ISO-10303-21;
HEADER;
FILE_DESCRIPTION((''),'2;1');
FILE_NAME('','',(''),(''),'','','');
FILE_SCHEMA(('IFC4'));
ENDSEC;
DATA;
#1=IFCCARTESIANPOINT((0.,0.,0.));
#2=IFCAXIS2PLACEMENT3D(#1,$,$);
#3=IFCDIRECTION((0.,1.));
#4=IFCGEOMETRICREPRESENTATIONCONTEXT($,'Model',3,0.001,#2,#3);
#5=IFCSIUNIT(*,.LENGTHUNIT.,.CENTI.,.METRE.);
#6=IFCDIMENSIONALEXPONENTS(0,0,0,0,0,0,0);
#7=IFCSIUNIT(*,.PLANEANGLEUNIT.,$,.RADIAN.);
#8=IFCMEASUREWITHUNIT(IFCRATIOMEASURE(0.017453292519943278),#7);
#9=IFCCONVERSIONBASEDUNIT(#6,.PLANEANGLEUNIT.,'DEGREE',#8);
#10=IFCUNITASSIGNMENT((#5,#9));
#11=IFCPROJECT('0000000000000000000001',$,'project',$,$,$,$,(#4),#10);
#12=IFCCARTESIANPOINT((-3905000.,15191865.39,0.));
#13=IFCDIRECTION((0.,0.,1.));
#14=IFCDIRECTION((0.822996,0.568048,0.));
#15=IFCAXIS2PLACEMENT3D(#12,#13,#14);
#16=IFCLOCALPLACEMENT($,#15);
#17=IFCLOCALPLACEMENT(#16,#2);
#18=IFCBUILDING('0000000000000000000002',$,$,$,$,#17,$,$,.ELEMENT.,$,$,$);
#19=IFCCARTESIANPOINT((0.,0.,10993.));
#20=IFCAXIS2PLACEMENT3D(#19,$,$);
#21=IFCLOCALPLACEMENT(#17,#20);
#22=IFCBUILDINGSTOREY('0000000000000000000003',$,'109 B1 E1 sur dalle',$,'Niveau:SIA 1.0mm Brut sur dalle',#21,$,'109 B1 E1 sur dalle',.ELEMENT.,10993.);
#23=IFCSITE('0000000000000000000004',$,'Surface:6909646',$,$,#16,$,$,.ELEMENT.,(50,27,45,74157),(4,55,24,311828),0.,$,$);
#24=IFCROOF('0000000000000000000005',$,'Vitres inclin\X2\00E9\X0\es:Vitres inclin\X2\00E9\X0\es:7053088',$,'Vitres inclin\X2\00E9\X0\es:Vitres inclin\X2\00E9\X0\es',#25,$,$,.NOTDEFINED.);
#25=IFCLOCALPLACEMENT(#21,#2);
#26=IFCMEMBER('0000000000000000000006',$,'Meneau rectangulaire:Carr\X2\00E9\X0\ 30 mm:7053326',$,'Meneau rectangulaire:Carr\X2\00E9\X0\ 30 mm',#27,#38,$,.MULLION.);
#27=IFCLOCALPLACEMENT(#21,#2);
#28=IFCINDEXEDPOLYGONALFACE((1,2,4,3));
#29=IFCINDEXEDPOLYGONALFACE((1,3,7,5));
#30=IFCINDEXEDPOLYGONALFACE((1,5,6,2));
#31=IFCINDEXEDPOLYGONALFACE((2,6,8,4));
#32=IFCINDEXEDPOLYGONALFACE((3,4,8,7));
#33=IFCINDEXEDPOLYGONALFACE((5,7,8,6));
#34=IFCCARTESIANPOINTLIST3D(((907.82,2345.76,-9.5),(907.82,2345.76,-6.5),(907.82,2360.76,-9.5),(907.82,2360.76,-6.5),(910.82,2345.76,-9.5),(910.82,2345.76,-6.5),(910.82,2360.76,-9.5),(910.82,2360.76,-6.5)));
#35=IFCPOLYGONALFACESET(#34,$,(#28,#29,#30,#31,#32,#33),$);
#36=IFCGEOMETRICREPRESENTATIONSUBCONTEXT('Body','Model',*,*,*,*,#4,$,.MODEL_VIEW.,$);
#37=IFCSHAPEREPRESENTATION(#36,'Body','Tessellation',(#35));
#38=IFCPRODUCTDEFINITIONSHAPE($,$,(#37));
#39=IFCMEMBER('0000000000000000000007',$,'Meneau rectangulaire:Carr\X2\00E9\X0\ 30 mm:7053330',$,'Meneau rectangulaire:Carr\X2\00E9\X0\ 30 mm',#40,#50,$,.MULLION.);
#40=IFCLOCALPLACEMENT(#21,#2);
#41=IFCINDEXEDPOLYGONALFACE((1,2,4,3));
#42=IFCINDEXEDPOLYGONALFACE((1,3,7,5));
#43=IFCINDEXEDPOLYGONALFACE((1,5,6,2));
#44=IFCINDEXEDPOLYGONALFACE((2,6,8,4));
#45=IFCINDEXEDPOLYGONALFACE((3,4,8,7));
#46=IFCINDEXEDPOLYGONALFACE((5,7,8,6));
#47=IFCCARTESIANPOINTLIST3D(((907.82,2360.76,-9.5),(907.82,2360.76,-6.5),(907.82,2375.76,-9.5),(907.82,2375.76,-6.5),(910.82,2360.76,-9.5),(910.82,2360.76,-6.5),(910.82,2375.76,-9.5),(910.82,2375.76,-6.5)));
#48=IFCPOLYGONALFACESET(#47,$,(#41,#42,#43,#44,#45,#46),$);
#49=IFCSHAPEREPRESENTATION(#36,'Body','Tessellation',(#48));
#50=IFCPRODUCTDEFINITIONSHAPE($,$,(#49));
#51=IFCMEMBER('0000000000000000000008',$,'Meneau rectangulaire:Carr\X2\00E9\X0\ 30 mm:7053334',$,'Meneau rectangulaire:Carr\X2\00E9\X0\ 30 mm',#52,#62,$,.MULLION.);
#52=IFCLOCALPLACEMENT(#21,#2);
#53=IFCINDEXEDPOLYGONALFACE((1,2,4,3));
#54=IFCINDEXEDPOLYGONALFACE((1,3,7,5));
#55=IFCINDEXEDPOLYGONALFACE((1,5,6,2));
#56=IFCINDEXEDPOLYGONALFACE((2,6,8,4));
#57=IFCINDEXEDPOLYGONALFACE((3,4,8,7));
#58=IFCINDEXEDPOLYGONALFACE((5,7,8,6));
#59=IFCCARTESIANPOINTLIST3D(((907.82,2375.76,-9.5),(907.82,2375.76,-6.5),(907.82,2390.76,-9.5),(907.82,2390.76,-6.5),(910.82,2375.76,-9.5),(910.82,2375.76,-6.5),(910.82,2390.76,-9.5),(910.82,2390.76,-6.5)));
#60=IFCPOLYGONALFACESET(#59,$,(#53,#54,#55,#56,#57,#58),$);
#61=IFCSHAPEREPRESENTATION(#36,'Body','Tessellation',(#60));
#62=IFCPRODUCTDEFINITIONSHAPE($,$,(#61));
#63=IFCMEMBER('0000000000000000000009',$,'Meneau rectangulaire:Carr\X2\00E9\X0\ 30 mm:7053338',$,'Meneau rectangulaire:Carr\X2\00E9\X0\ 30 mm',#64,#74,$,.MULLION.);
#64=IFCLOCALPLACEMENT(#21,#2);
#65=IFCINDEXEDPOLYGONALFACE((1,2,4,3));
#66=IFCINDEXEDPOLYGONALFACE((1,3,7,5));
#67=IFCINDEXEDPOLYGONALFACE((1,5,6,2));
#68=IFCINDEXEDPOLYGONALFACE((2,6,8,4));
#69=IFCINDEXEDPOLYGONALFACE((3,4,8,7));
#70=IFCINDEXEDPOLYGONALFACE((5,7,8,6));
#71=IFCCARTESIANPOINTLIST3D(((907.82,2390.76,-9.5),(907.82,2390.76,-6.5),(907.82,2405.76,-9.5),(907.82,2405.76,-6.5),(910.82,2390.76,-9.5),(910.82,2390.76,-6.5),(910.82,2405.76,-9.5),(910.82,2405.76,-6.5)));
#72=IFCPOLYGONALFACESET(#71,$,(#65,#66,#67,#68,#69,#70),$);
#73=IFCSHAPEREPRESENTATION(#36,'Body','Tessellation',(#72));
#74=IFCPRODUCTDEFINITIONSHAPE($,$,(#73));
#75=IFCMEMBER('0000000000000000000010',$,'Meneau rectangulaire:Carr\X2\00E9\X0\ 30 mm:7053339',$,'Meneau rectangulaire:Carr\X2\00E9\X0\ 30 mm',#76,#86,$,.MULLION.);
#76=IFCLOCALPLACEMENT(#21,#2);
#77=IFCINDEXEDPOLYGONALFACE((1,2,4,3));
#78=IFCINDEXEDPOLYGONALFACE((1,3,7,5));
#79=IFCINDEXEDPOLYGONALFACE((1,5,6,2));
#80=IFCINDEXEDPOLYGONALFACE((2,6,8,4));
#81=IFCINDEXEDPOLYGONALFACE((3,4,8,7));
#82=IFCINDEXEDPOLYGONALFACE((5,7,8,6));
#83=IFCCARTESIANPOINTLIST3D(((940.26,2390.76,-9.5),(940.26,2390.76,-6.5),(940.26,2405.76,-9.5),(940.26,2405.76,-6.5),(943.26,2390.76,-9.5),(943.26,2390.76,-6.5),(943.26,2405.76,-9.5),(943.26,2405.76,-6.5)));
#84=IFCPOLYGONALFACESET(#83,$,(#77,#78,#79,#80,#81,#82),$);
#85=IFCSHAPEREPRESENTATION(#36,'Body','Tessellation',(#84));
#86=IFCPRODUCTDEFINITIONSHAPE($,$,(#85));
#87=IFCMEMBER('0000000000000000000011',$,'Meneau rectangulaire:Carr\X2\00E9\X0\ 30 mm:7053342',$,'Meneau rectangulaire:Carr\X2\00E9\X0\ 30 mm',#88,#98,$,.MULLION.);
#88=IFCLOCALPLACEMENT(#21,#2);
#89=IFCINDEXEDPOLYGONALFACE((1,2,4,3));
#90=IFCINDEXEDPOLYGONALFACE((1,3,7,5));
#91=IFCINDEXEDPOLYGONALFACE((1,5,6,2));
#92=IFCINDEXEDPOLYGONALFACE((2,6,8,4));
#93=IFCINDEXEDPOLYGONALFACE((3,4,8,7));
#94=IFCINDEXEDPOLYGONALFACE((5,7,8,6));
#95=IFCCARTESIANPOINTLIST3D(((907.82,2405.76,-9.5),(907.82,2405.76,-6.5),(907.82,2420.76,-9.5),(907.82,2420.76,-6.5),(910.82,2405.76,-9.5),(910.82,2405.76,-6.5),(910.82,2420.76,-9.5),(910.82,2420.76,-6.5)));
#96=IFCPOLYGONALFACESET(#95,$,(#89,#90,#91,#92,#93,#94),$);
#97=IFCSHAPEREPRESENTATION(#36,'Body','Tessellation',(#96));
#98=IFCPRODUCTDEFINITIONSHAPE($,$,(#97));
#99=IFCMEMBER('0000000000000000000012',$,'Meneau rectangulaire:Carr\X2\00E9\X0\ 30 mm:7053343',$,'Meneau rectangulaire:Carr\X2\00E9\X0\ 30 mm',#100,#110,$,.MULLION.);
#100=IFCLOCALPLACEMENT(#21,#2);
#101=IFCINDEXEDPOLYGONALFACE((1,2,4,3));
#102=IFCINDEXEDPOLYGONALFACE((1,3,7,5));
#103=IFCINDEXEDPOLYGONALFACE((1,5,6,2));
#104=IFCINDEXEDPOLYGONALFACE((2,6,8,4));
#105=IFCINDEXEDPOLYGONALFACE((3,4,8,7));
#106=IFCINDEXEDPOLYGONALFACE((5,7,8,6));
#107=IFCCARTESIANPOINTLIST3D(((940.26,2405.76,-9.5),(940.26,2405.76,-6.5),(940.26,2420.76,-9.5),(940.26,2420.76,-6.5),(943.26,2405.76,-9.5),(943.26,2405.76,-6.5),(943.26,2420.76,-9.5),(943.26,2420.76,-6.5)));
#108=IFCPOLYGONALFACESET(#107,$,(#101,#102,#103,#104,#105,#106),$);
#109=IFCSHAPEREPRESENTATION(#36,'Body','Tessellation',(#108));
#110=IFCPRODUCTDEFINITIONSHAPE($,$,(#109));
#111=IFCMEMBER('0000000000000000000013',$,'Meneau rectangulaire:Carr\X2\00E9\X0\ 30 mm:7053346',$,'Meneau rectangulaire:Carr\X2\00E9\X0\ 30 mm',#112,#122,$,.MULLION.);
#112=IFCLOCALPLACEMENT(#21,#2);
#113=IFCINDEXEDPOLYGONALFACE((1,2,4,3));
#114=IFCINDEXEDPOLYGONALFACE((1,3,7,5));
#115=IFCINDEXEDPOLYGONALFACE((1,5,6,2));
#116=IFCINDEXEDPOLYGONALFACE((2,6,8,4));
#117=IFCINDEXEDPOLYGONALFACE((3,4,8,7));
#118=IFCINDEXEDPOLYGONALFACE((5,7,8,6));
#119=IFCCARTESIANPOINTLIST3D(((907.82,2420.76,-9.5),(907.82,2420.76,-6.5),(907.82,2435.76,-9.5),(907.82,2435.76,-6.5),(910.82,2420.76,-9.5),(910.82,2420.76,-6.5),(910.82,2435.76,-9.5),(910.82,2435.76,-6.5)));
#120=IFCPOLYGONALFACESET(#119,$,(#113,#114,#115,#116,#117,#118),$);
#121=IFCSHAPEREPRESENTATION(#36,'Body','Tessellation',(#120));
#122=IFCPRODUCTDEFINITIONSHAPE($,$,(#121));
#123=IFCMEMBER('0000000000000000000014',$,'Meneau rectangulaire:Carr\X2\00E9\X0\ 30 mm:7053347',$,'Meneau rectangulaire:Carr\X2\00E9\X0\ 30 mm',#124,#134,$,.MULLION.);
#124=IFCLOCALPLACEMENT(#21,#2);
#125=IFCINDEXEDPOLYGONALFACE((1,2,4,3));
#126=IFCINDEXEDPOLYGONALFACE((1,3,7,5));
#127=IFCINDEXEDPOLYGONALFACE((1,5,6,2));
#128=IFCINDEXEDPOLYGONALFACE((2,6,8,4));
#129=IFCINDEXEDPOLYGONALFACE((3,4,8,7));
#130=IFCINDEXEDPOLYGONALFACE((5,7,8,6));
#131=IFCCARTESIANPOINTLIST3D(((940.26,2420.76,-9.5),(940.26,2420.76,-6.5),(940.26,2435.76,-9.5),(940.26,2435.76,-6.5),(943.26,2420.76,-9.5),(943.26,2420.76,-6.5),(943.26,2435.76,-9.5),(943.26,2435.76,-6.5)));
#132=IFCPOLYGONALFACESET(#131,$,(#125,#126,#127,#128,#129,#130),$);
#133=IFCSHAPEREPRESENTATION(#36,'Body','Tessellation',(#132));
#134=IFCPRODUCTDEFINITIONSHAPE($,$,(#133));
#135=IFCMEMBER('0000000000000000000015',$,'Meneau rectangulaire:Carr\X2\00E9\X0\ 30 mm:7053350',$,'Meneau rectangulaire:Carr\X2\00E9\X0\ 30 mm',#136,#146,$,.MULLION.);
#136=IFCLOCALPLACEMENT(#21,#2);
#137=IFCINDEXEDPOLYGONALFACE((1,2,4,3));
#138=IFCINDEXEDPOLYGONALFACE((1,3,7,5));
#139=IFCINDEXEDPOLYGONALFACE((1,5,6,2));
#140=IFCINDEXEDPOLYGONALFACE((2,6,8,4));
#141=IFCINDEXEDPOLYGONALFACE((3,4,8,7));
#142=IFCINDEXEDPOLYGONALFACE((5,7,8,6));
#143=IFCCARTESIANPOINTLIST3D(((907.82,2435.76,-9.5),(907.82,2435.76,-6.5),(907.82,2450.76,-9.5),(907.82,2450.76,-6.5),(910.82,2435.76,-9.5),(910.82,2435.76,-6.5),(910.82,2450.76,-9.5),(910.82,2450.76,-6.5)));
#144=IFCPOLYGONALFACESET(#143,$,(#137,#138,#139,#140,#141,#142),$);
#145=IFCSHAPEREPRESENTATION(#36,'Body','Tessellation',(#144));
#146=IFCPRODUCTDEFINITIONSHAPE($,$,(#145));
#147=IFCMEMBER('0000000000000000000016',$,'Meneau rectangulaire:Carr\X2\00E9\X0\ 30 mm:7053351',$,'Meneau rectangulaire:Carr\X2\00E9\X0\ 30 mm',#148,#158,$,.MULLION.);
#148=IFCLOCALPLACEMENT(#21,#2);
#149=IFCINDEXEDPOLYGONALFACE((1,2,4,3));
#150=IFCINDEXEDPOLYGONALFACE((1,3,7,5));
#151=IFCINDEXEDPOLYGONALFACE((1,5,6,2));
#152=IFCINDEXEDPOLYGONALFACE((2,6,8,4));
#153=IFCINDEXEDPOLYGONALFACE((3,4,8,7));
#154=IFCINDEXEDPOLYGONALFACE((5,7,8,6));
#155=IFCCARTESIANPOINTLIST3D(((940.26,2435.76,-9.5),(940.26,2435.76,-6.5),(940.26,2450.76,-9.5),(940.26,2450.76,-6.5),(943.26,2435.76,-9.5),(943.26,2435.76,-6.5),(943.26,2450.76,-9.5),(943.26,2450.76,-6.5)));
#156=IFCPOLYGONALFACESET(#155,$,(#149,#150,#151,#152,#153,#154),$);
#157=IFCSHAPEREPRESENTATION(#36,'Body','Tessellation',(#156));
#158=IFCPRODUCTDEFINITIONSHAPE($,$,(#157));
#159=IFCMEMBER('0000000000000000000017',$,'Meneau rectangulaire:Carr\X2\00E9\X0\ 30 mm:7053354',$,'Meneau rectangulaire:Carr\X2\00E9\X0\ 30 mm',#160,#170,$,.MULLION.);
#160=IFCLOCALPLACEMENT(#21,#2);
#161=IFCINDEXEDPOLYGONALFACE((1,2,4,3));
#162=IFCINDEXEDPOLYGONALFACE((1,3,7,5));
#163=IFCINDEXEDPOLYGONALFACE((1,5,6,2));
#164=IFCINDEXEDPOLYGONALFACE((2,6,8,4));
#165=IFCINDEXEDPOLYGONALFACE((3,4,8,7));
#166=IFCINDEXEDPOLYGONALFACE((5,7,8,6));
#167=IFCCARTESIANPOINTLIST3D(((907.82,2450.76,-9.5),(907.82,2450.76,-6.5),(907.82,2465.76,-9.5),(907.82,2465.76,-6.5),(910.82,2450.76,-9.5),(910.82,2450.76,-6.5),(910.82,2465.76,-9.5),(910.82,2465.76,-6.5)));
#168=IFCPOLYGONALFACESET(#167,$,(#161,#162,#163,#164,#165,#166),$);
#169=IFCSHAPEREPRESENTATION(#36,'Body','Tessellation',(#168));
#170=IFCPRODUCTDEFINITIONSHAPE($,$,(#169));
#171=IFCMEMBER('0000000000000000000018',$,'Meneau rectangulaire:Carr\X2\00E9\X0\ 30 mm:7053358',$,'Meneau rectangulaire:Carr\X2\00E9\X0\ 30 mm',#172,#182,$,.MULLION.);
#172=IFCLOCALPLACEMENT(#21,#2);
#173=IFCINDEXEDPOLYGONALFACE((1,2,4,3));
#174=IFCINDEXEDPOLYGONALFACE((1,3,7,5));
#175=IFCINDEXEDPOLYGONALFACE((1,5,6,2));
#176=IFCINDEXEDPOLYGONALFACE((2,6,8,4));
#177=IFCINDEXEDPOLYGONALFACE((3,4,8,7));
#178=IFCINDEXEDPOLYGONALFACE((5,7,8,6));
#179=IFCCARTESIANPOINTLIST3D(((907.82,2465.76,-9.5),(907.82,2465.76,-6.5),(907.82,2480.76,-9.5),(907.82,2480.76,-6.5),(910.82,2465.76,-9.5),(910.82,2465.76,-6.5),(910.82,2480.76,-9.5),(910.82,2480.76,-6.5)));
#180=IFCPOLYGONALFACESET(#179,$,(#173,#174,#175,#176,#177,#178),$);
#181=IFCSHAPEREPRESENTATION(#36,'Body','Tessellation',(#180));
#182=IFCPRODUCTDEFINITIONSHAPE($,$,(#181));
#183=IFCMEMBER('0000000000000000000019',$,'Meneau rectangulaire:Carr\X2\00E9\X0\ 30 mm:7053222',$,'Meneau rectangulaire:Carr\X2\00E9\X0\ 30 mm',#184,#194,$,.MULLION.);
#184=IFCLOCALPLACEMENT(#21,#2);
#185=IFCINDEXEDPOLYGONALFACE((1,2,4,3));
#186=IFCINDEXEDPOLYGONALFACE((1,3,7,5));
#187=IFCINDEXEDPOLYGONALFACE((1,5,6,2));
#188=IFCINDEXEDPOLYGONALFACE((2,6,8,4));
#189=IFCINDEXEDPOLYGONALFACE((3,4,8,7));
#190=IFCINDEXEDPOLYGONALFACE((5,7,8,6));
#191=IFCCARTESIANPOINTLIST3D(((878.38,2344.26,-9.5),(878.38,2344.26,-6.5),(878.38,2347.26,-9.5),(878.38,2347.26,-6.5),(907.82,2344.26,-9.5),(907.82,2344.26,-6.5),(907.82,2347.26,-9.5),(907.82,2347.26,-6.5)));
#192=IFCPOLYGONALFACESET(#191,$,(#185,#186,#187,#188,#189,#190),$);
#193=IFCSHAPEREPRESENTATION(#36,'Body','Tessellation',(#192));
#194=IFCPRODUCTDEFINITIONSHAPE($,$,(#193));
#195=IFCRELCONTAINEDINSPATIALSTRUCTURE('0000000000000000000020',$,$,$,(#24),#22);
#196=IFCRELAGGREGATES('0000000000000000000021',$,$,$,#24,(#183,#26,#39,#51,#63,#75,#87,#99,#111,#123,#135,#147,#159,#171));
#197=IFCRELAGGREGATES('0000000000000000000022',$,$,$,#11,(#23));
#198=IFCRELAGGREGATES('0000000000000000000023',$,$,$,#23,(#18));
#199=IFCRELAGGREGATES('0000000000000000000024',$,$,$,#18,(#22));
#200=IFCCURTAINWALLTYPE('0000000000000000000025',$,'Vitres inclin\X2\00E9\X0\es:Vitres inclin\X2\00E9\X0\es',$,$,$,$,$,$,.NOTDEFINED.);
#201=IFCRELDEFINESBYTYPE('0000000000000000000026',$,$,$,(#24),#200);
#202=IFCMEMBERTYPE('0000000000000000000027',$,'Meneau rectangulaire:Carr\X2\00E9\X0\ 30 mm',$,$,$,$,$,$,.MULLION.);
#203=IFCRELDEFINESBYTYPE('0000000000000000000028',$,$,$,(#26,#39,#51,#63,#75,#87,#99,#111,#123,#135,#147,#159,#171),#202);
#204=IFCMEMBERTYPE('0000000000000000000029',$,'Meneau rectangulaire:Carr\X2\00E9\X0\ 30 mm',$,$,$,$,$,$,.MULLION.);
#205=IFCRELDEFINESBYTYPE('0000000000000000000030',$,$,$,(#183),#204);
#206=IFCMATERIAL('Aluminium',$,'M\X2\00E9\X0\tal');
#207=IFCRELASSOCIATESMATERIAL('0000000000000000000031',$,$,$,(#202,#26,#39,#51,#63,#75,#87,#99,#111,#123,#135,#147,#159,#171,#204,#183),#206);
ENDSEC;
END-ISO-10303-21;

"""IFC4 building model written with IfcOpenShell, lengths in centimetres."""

from ifc_helpers import new_model, entity, si_unit, converted_unit, direction, frame, origin, place, context, subcontext, project, spatial, indexed_curve, outline, extrude, source, transform, mapped, material, type_object, type_shapes, element, aggregate, save


model = new_model("IFC4")

# Units and contexts
model_context = context("Model", 3, precision=0.001, world=origin(), true_north=direction((0.0, 1.0)))
body_context = subcontext(model_context, "Body", "Model", "MODEL_VIEW")
ifc_project = project(units=[si_unit("LENGTHUNIT", "METRE", prefix="CENTI"), converted_unit("PLANEANGLEUNIT", "DEGREE", entity("IfcRatioMeasure", 0.017453292519943278), si_unit("PLANEANGLEUNIT", "RADIAN"), dimensions=[0, 0, 0, 0, 0, 0, 0])], contexts=[model_context])

# Site, building, storey
site_placement = place(None, frame((-3905000.0, 15191865.39, 0.0), z_axis=(0.0, 0.0, 1.0), x_axis=(0.822996, 0.568048, 0.0)))
site = spatial("IfcSite", under=ifc_project, at=site_placement, Name="Surface:6909646", CompositionType="ELEMENT", RefLatitude=(50, 27, 45, 74157), RefLongitude=(4, 55, 24, 311828), RefElevation=0.0)
building_placement = place(site_placement, origin())
building = spatial("IfcBuilding", under=site, at=building_placement, CompositionType="ELEMENT")
storey_placement = place(building_placement, frame((0.0, 0.0, 10993.0)))
storey = spatial("IfcBuildingStorey", under=building, at=storey_placement, Name="109 B1 E1 sur dalle", ObjectType="Niveau:SIA 1.0mm Brut sur dalle", LongName="109 B1 E1 sur dalle", CompositionType="ELEMENT", Elevation=10993.0)

# Roof, members
curtain_wall_type = type_object("IfcCurtainWallType", Name="Vitres inclinées:Vitres inclinées", PredefinedType="NOTDEFINED")
roof_placement = place(storey_placement, frame((0.0, 0.0, -10993.0)))
roof = element("IfcRoof", 1, at=roof_placement, inside=storey, type_object=curtain_wall_type, Name="Vitres inclinées:Vitres inclinées:7053088", ObjectType="Vitres inclinées:Vitres inclinées", PredefinedType="NOTDEFINED")
ifc_material = material(Name="Aluminium", Category="Métal")
member_type_1 = type_object("IfcMemberType", Name="Meneau rectangulaire:Carré 30 mm", PredefinedType="MULLION", material=ifc_material)
shared_shape_1 = source(origin(), body_context, "Body", "SweptSolid", [
    extrude(outline(indexed_curve([(-1.5, -1.5), (1.5, -1.5), (1.5, 1.5), (-1.5, 1.5), (-1.5, -1.5)], self_intersect=False)), frame((0.0, 0.0, -15.0), z_axis=(0.0, 0.0, 1.0), x_axis=(0.0, -1.0, 0.0)), (0.0, 0.0, 1.0), 15.0),
])
type_shapes(member_type_1, [shared_shape_1])
member_1_placement = place(roof_placement, frame((909.32, 2360.76, 10985.0), z_axis=(0.0, 1.0, 0.0), x_axis=(1.0, 0.0, 0.0)))
member_1 = element("IfcMember", 2, at=member_1_placement, type_object=member_type_1, material=ifc_material, Name="Meneau rectangulaire:Carré 30 mm:7053326", ObjectType="Meneau rectangulaire:Carré 30 mm", PredefinedType="MULLION", context=body_context, shape_type="MappedRepresentation", body=[
    mapped(shared_shape_1, transform((0.0, 0.0, 0.0), scale=1.0)),
])
member_2_placement = place(roof_placement, frame((909.32, 2375.76, 10985.0), z_axis=(0.0, 1.0, 0.0), x_axis=(1.0, 0.0, 0.0)))
member_2 = element("IfcMember", 3, at=member_2_placement, type_object=member_type_1, material=ifc_material, Name="Meneau rectangulaire:Carré 30 mm:7053330", ObjectType="Meneau rectangulaire:Carré 30 mm", PredefinedType="MULLION", context=body_context, shape_type="MappedRepresentation", body=[
    mapped(shared_shape_1, transform((0.0, 0.0, 0.0), scale=1.0)),
])
member_3_placement = place(roof_placement, frame((909.32, 2390.76, 10985.0), z_axis=(0.0, 1.0, 0.0), x_axis=(1.0, 0.0, 0.0)))
member_3 = element("IfcMember", 4, at=member_3_placement, type_object=member_type_1, material=ifc_material, Name="Meneau rectangulaire:Carré 30 mm:7053334", ObjectType="Meneau rectangulaire:Carré 30 mm", PredefinedType="MULLION", context=body_context, shape_type="MappedRepresentation", body=[
    mapped(shared_shape_1, transform((0.0, 0.0, 0.0), scale=1.0)),
])
member_4_placement = place(roof_placement, frame((909.32, 2405.76, 10985.0), z_axis=(0.0, 1.0, 0.0), x_axis=(1.0, 0.0, 0.0)))
member_4 = element("IfcMember", 5, at=member_4_placement, type_object=member_type_1, material=ifc_material, Name="Meneau rectangulaire:Carré 30 mm:7053338", ObjectType="Meneau rectangulaire:Carré 30 mm", PredefinedType="MULLION", context=body_context, shape_type="MappedRepresentation", body=[
    mapped(shared_shape_1, transform((0.0, 0.0, 0.0), scale=1.0)),
])
member_5_placement = place(roof_placement, frame((941.76, 2405.76, 10985.0), z_axis=(0.0, 1.0, 0.0), x_axis=(1.0, 0.0, 0.0)))
member_5 = element("IfcMember", 6, at=member_5_placement, type_object=member_type_1, material=ifc_material, Name="Meneau rectangulaire:Carré 30 mm:7053339", ObjectType="Meneau rectangulaire:Carré 30 mm", PredefinedType="MULLION", context=body_context, shape_type="MappedRepresentation", body=[
    mapped(shared_shape_1, transform((0.0, 0.0, 0.0), scale=1.0)),
])
member_6_placement = place(roof_placement, frame((909.32, 2420.76, 10985.0), z_axis=(0.0, 1.0, 0.0), x_axis=(1.0, 0.0, 0.0)))
member_6 = element("IfcMember", 7, at=member_6_placement, type_object=member_type_1, material=ifc_material, Name="Meneau rectangulaire:Carré 30 mm:7053342", ObjectType="Meneau rectangulaire:Carré 30 mm", PredefinedType="MULLION", context=body_context, shape_type="MappedRepresentation", body=[
    mapped(shared_shape_1, transform((0.0, 0.0, 0.0), scale=1.0)),
])
member_7_placement = place(roof_placement, frame((941.76, 2420.76, 10985.0), z_axis=(0.0, 1.0, 0.0), x_axis=(1.0, 0.0, 0.0)))
member_7 = element("IfcMember", 8, at=member_7_placement, type_object=member_type_1, material=ifc_material, Name="Meneau rectangulaire:Carré 30 mm:7053343", ObjectType="Meneau rectangulaire:Carré 30 mm", PredefinedType="MULLION", context=body_context, shape_type="MappedRepresentation", body=[
    mapped(shared_shape_1, transform((0.0, 0.0, 0.0), scale=1.0)),
])
member_8_placement = place(roof_placement, frame((909.32, 2435.76, 10985.0), z_axis=(0.0, 1.0, 0.0), x_axis=(1.0, 0.0, 0.0)))
member_8 = element("IfcMember", 9, at=member_8_placement, type_object=member_type_1, material=ifc_material, Name="Meneau rectangulaire:Carré 30 mm:7053346", ObjectType="Meneau rectangulaire:Carré 30 mm", PredefinedType="MULLION", context=body_context, shape_type="MappedRepresentation", body=[
    mapped(shared_shape_1, transform((0.0, 0.0, 0.0), scale=1.0)),
])
member_9_placement = place(roof_placement, frame((941.76, 2435.76, 10985.0), z_axis=(0.0, 1.0, 0.0), x_axis=(1.0, 0.0, 0.0)))
member_9 = element("IfcMember", 10, at=member_9_placement, type_object=member_type_1, material=ifc_material, Name="Meneau rectangulaire:Carré 30 mm:7053347", ObjectType="Meneau rectangulaire:Carré 30 mm", PredefinedType="MULLION", context=body_context, shape_type="MappedRepresentation", body=[
    mapped(shared_shape_1, transform((0.0, 0.0, 0.0), scale=1.0)),
])
member_10_placement = place(roof_placement, frame((909.32, 2450.76, 10985.0), z_axis=(0.0, 1.0, 0.0), x_axis=(1.0, 0.0, 0.0)))
member_10 = element("IfcMember", 11, at=member_10_placement, type_object=member_type_1, material=ifc_material, Name="Meneau rectangulaire:Carré 30 mm:7053350", ObjectType="Meneau rectangulaire:Carré 30 mm", PredefinedType="MULLION", context=body_context, shape_type="MappedRepresentation", body=[
    mapped(shared_shape_1, transform((0.0, 0.0, 0.0), scale=1.0)),
])
member_11_placement = place(roof_placement, frame((941.76, 2450.76, 10985.0), z_axis=(0.0, 1.0, 0.0), x_axis=(1.0, 0.0, 0.0)))
member_11 = element("IfcMember", 12, at=member_11_placement, type_object=member_type_1, material=ifc_material, Name="Meneau rectangulaire:Carré 30 mm:7053351", ObjectType="Meneau rectangulaire:Carré 30 mm", PredefinedType="MULLION", context=body_context, shape_type="MappedRepresentation", body=[
    mapped(shared_shape_1, transform((0.0, 0.0, 0.0), scale=1.0)),
])
member_12_placement = place(roof_placement, frame((909.32, 2465.76, 10985.0), z_axis=(0.0, 1.0, 0.0), x_axis=(1.0, 0.0, 0.0)))
member_12 = element("IfcMember", 13, at=member_12_placement, type_object=member_type_1, material=ifc_material, Name="Meneau rectangulaire:Carré 30 mm:7053354", ObjectType="Meneau rectangulaire:Carré 30 mm", PredefinedType="MULLION", context=body_context, shape_type="MappedRepresentation", body=[
    mapped(shared_shape_1, transform((0.0, 0.0, 0.0), scale=1.0)),
])
member_13_placement = place(roof_placement, frame((909.32, 2480.76, 10985.0), z_axis=(0.0, 1.0, 0.0), x_axis=(1.0, 0.0, 0.0)))
member_13 = element("IfcMember", 14, at=member_13_placement, type_object=member_type_1, material=ifc_material, Name="Meneau rectangulaire:Carré 30 mm:7053358", ObjectType="Meneau rectangulaire:Carré 30 mm", PredefinedType="MULLION", context=body_context, shape_type="MappedRepresentation", body=[
    mapped(shared_shape_1, transform((0.0, 0.0, 0.0), scale=1.0)),
])
member_type_2 = type_object("IfcMemberType", Name="Meneau rectangulaire:Carré 30 mm", PredefinedType="MULLION", material=ifc_material)
shared_shape_2 = source(origin(), body_context, "Body", "SweptSolid", [
    extrude(outline(indexed_curve([(-1.5, -1.5), (1.5, -1.5), (1.5, 1.5), (-1.5, 1.5), (-1.5, -1.5)], self_intersect=False)), frame((0.0, 0.0, -29.44), z_axis=(0.0, 0.0, 1.0), x_axis=(0.0, -1.0, 0.0)), (0.0, 0.0, 1.0), 29.44),
])
type_shapes(member_type_2, [shared_shape_2])
member_14_placement = place(roof_placement, frame((878.38, 2345.76, 10985.0), z_axis=(-1.0, 0.0, 0.0), x_axis=(0.0, 1.0, 0.0)))
member_14 = element("IfcMember", 15, at=member_14_placement, type_object=member_type_2, material=ifc_material, Name="Meneau rectangulaire:Carré 30 mm:7053222", ObjectType="Meneau rectangulaire:Carré 30 mm", PredefinedType="MULLION", context=body_context, shape_type="MappedRepresentation", body=[
    mapped(shared_shape_2, transform((0.0, 0.0, 0.0), scale=1.0)),
])
aggregate(roof, [member_14, member_1, member_2, member_3, member_4, member_5, member_6, member_7, member_8, member_9, member_10, member_11, member_12, member_13])

save(model, "model.ifc")
